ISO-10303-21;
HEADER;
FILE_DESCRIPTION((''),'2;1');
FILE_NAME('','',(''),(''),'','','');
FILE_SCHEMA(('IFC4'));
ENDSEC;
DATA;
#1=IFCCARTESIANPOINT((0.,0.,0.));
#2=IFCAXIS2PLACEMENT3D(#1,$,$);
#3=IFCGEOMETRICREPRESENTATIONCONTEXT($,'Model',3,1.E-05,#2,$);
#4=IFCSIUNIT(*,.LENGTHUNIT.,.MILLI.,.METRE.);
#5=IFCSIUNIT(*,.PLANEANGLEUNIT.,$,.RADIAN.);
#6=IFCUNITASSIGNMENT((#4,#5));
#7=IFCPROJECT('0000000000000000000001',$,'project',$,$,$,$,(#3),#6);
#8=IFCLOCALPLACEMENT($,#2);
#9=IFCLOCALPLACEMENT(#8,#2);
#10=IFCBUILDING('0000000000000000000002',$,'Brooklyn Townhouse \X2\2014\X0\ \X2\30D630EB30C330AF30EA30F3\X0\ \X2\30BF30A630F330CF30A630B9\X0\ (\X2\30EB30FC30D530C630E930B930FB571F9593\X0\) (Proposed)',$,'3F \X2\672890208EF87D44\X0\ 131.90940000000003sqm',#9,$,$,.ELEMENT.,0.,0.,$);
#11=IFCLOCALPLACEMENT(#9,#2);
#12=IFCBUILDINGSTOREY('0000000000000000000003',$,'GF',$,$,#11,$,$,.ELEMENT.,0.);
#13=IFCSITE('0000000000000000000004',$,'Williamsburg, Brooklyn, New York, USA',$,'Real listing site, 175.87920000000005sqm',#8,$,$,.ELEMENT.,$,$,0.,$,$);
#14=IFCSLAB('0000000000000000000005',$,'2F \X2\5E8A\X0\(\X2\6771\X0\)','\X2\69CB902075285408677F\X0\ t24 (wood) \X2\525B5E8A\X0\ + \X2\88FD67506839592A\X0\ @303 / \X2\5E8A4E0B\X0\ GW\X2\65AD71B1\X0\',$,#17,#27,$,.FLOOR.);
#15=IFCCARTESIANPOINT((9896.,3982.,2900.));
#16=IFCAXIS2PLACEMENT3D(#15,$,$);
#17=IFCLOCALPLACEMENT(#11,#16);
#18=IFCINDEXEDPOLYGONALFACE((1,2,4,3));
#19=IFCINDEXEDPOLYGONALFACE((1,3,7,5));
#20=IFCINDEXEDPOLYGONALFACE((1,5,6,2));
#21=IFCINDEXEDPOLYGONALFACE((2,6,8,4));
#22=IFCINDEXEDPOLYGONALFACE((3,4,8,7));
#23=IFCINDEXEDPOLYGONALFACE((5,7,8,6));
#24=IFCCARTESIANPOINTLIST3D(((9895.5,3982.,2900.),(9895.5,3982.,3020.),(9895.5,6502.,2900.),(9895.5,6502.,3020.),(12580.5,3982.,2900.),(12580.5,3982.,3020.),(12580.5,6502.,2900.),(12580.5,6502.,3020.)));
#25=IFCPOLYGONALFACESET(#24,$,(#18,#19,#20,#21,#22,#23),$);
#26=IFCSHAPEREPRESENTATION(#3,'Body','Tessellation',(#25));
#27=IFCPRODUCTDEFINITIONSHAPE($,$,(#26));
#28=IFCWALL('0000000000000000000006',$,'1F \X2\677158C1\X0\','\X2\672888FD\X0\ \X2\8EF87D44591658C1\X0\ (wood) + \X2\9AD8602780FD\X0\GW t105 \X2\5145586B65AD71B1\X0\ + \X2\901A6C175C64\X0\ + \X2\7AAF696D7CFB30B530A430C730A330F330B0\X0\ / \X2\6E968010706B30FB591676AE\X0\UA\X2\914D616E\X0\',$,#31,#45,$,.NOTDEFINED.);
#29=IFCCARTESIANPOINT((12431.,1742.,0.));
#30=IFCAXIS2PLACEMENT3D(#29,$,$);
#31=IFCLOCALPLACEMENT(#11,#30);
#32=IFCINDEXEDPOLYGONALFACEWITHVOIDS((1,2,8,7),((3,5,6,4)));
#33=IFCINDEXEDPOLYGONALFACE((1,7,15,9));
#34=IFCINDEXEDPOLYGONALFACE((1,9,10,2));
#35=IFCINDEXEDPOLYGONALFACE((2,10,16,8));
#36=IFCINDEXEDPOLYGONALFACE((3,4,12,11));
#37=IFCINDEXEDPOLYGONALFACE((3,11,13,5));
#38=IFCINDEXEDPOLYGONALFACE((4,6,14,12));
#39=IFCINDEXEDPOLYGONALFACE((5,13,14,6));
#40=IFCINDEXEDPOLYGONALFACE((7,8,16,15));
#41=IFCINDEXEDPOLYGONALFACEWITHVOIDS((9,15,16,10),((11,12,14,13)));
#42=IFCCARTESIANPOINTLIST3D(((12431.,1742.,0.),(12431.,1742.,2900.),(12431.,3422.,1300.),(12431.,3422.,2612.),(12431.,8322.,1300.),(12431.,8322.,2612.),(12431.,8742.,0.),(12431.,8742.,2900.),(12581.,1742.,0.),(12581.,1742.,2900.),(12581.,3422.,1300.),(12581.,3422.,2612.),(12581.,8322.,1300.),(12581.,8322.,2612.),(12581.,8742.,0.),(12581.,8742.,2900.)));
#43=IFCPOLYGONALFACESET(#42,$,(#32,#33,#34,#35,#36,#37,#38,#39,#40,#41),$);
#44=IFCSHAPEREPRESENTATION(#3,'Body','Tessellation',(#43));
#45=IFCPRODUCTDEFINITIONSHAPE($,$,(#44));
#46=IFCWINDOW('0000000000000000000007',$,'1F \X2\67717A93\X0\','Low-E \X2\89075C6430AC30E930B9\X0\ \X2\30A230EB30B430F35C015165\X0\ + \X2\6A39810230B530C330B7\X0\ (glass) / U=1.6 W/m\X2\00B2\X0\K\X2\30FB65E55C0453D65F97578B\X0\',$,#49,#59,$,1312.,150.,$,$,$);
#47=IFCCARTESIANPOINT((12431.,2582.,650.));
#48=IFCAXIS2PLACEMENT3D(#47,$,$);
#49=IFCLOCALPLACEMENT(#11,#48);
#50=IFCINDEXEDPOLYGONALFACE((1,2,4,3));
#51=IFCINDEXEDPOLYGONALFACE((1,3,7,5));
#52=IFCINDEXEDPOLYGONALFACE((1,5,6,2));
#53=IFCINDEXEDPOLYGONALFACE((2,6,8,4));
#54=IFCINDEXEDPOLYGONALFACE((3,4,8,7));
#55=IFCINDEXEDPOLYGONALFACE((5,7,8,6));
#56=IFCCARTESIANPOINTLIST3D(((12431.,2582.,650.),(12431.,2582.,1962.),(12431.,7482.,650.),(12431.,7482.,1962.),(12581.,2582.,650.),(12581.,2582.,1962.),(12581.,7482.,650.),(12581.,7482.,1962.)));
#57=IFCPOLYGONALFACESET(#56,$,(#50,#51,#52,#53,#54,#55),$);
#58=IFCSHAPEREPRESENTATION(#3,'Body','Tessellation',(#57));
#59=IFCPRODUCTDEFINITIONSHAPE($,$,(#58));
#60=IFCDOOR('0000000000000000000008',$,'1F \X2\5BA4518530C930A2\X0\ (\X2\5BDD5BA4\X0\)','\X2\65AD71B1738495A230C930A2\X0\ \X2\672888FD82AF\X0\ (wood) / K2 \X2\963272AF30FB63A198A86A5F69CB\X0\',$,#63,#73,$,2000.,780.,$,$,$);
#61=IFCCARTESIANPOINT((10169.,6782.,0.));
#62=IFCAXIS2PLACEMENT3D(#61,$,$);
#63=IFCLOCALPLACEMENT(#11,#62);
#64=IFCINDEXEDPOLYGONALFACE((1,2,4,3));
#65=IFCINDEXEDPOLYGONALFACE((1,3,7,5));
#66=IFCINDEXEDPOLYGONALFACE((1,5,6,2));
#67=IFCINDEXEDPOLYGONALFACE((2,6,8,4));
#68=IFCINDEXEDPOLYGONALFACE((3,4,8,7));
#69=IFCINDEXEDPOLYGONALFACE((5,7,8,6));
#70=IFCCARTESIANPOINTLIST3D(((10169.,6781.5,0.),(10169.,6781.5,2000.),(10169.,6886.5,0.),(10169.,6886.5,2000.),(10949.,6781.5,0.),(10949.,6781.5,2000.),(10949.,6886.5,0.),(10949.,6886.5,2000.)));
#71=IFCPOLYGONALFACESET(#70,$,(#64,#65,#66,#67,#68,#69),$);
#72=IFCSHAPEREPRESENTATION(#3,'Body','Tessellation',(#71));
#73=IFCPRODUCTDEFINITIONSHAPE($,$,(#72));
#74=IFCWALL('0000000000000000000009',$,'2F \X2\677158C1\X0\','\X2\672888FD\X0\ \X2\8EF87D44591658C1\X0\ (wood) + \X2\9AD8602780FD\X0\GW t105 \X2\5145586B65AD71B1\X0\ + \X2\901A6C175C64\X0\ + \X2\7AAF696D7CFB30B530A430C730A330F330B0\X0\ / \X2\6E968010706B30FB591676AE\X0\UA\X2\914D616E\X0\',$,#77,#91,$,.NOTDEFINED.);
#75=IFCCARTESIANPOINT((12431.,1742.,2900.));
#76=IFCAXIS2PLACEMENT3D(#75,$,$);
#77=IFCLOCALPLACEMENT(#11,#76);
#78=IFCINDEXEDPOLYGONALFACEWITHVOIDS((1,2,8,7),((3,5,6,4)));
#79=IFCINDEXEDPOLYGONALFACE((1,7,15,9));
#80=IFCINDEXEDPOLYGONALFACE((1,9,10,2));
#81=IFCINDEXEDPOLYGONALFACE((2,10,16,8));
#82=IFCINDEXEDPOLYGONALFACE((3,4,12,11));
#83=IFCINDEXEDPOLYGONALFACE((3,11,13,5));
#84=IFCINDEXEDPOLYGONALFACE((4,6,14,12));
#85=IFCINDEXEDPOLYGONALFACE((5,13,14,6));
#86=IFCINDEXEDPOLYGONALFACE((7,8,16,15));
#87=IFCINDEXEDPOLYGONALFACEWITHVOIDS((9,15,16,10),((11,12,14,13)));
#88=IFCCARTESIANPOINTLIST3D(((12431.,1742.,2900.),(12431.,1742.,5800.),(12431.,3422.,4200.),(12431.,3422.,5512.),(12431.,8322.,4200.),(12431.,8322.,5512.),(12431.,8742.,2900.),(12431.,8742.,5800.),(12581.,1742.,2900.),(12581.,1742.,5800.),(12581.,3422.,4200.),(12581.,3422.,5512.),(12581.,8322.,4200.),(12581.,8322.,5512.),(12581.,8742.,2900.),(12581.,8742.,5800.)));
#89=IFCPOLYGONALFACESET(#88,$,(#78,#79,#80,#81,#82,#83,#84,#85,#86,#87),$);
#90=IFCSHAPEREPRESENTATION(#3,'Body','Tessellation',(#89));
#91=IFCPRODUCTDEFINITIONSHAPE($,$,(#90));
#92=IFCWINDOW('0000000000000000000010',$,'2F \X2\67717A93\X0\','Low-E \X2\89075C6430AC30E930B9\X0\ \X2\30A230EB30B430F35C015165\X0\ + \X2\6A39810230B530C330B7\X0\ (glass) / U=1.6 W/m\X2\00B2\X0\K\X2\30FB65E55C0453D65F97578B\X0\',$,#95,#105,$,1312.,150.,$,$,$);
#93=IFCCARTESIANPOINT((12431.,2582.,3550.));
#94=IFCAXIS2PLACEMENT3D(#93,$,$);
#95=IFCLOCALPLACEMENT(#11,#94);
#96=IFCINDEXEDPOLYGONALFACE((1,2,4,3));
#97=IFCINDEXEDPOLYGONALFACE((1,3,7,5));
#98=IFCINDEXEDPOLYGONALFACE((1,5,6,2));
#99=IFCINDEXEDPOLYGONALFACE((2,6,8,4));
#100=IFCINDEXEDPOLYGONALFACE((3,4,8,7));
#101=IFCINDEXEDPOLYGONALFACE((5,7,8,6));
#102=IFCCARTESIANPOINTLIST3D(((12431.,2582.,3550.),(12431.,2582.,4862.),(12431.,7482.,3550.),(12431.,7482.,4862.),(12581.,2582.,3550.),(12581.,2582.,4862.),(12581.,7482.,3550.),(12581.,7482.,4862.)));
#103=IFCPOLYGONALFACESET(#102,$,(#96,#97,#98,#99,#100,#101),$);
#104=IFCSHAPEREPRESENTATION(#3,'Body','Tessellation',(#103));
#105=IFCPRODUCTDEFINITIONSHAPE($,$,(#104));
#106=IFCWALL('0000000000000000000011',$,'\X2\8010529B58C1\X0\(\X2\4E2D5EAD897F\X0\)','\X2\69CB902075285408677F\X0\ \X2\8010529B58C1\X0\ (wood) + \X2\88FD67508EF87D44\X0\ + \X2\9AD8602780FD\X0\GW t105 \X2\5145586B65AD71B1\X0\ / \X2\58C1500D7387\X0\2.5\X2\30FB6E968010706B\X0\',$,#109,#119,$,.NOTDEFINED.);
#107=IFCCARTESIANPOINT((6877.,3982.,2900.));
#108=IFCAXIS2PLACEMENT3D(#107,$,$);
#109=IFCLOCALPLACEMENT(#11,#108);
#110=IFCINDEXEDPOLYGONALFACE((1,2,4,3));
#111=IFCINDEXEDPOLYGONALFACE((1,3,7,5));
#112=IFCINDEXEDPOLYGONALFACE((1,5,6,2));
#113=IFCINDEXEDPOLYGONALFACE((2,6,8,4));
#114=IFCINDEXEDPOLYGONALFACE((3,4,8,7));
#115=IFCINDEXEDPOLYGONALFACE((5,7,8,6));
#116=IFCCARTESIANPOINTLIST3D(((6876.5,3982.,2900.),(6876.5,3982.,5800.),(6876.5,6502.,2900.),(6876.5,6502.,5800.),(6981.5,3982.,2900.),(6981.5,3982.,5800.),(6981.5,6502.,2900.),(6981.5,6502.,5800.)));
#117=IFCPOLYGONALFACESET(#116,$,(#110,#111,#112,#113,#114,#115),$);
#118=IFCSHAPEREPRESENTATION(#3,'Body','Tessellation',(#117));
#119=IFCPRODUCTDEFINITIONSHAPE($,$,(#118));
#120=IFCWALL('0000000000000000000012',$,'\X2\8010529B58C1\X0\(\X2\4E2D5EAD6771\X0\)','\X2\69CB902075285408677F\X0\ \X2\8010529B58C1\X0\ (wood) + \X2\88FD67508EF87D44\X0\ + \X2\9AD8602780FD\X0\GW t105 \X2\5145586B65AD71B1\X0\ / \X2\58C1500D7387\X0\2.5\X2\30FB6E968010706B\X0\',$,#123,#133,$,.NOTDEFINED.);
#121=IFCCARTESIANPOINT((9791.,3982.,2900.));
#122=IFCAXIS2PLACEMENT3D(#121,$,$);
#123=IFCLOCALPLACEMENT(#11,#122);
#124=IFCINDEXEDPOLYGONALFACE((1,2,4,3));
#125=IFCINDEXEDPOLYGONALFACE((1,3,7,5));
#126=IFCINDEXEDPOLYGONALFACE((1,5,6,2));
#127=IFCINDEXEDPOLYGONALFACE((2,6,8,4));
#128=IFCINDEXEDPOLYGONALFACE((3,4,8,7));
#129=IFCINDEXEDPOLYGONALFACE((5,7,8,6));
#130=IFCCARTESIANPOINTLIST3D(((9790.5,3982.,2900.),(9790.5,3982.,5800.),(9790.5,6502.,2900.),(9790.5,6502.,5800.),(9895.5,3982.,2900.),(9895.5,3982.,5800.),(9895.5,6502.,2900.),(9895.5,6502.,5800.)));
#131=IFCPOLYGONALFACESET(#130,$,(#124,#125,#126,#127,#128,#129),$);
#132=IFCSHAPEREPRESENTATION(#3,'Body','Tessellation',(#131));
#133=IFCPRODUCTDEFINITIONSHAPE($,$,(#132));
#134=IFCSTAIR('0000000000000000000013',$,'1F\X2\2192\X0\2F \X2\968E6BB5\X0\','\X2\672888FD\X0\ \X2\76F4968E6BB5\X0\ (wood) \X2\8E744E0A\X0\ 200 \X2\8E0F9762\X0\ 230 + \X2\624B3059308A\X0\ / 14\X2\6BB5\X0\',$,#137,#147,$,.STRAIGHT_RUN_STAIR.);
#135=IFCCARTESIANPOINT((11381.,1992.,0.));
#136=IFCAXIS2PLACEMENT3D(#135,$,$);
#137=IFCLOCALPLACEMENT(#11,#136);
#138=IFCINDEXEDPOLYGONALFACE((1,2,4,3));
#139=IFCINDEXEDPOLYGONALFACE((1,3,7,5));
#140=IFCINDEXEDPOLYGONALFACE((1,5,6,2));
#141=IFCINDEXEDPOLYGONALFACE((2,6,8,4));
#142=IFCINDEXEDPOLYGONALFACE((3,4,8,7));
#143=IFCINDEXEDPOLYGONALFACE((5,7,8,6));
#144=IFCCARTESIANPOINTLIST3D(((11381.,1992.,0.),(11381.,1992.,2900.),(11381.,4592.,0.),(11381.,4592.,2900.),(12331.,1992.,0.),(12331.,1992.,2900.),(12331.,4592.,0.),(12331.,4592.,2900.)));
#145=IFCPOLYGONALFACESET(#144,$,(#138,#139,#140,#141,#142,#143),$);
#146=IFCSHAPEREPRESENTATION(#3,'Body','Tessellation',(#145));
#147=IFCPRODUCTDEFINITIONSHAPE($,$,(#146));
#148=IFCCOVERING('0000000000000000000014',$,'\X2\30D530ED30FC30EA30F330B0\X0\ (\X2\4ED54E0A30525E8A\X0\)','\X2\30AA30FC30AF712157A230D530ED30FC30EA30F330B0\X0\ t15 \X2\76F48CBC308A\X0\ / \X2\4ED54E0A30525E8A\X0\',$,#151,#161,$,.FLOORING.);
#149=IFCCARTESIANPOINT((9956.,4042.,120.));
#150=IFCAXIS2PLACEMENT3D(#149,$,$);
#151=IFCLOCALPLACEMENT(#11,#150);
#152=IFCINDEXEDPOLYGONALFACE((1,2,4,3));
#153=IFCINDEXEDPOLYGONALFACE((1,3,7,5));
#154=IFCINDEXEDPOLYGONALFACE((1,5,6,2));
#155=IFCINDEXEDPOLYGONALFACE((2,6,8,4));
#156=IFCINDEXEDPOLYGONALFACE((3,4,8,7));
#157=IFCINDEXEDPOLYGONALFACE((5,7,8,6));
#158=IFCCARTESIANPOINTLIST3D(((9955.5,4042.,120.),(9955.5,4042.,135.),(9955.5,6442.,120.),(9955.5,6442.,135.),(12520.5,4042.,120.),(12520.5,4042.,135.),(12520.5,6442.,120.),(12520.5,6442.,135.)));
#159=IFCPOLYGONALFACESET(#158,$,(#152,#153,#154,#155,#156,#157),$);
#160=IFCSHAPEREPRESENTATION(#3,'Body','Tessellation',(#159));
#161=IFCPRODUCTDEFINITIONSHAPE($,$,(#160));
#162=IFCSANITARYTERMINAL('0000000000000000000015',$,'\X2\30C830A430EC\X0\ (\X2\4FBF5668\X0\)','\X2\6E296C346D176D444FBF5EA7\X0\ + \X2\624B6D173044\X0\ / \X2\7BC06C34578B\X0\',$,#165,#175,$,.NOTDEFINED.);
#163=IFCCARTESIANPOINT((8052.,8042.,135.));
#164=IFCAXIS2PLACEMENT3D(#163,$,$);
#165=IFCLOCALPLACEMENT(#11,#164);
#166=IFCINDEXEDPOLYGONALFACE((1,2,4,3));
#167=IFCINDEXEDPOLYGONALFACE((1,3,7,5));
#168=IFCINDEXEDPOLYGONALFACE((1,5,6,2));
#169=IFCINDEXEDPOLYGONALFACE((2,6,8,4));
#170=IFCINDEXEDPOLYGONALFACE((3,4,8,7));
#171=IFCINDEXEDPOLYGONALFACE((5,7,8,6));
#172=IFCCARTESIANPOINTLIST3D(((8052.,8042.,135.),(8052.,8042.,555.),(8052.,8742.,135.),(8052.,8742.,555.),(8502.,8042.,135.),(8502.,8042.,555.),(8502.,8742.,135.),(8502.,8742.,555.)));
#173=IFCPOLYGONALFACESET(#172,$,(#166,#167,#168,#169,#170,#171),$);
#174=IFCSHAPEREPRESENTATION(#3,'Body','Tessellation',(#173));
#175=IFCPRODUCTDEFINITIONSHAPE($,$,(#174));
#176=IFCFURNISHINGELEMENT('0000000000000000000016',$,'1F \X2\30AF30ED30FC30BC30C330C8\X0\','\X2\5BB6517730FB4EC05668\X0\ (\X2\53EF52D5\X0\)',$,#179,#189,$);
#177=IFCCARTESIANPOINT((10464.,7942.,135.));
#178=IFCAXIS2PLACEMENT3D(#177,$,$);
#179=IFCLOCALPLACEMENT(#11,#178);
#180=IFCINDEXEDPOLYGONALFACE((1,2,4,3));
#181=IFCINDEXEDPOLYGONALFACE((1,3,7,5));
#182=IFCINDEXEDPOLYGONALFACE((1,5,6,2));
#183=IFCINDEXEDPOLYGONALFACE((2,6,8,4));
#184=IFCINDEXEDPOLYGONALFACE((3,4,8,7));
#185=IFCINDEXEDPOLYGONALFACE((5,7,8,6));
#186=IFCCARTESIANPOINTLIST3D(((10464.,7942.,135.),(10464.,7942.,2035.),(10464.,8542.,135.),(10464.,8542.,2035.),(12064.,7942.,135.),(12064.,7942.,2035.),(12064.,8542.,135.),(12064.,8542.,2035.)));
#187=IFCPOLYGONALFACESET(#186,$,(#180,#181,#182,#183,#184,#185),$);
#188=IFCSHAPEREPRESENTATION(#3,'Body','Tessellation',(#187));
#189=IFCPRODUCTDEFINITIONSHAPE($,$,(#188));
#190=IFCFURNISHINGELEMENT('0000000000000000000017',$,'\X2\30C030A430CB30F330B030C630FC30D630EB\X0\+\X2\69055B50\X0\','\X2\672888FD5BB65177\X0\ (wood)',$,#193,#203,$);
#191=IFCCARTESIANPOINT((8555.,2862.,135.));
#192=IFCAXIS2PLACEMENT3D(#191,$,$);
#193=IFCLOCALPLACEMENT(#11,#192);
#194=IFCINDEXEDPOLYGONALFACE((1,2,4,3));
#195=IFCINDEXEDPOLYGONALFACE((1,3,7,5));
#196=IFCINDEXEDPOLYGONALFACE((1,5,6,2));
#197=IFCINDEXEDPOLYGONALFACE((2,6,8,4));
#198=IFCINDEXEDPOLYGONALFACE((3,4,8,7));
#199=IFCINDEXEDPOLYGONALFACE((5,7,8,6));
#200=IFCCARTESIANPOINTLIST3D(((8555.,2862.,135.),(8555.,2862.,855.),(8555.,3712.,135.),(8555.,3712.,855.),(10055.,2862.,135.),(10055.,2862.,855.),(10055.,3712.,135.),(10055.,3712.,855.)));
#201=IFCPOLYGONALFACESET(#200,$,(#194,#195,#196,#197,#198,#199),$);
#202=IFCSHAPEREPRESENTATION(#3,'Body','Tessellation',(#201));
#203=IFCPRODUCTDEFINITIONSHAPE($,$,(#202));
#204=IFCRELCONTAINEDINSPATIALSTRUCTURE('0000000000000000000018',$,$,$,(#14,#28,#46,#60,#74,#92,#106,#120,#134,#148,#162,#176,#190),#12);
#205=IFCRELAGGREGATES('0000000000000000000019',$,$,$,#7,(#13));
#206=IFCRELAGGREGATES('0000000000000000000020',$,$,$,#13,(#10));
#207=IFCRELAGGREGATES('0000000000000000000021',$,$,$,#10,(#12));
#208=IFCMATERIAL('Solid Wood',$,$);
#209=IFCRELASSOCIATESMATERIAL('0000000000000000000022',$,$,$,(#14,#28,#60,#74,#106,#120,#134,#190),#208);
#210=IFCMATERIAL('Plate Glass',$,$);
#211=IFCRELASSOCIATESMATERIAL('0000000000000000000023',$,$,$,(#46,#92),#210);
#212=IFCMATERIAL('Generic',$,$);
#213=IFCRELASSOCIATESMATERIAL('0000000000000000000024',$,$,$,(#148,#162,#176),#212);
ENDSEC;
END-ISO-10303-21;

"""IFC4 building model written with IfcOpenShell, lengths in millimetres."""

from ifc_helpers import new_model, si_unit, frame, frame_2d, origin, place, context, project, spatial, rectangle, extrude, material, element, fill, save


model = new_model("IFC4")

# Units and contexts
model_context = context("Model", 3, precision=1e-05, world=origin())
ifc_project = project(units=[si_unit("LENGTHUNIT", "METRE", prefix="MILLI"), si_unit("PLANEANGLEUNIT", "RADIAN")], contexts=[model_context])

# Site, building, storey
site_placement = place(None, origin())
site = spatial("IfcSite", under=ifc_project, at=site_placement, Name="Williamsburg, Brooklyn, New York, USA", ObjectType="Real listing site, 175.87920000000005sqm", CompositionType="ELEMENT", RefElevation=0.0)
building_placement = place(site_placement, origin())
building = spatial("IfcBuilding", under=site, at=building_placement, Name="Brooklyn Townhouse — ブルックリン タウンハウス (ルーフテラス・土間) (Proposed)", ObjectType="3F 木造軸組 131.90940000000003sqm", CompositionType="ELEMENT", ElevationOfRefHeight=0.0, ElevationOfTerrain=0.0)
storey_placement = place(building_placement, origin())
storey = spatial("IfcBuildingStorey", under=building, at=storey_placement, Name="GF", CompositionType="ELEMENT", Elevation=0.0)

# Slab
ifc_material_1 = material(Name="Solid Wood")
slab_1_placement = place(storey_placement, frame((9896.0, 3982.0, 2900.0)))
element("IfcSlab", 1, at=slab_1_placement, inside=storey, material=ifc_material_1, Name="2F 床(東)", Description="構造用合板 t24 (wood) 剛床 + 製材根太 @303 / 床下 GW断熱", PredefinedType="FLOOR", context=model_context, shape_type="SweptSolid", body=[
    extrude(rectangle(XDim=2685.0, YDim=2520.0, at=frame_2d((1342.0, 1260.0))), frame((9896.0, 3982.0, 2900.0)), (0.0, 0.0, 1.0), 120.0),
])

# Wall, opening, window
wall_1_placement = place(storey_placement, frame((12431.0, 1742.0, 0.0)))
wall_1 = element("IfcWall", 2, at=wall_1_placement, inside=storey, material=ifc_material_1, Name="1F 東壁", Description="木製 軸組外壁 (wood) + 高性能GW t105 充填断熱 + 通気層 + 窯業系サイディング / 準耐火・外皮UA配慮", PredefinedType="NOTDEFINED", context=model_context, shape_type="SweptSolid", body=[
    extrude(rectangle(XDim=150.0, YDim=7000.0, at=frame_2d((75.0, 3500.0))), frame((12431.0, 1742.0, 0.0)), (0.0, 0.0, 1.0), 2900.0),
])
opening_1_placement = place(storey_placement, frame((12431.0, 2582.0, 650.0)))
opening_1 = element("IfcOpeningElement", 3, at=opening_1_placement, cuts=wall_1, PredefinedType="NOTDEFINED", context=model_context, shape_type="SweptSolid", body=[
    extrude(rectangle(XDim=150.0, YDim=4900.0, at=frame_2d((75.0, 2450.0))), frame((12431.0, 2582.0, 650.0)), (0.0, 0.0, 1.0), 1312.0),
])
ifc_material_2 = material(Name="Plate Glass")
window_1_placement = place(storey_placement, frame((12431.0, 2582.0, 650.0)))
window_1 = element("IfcWindow", 4, at=window_1_placement, inside=storey, material=ifc_material_2, Name="1F 東窓", Description="Low-E 複層ガラス アルゴン封入 + 樹脂サッシ (glass) / U=1.6 W/m²K・日射取得型", OverallHeight=1312.0, OverallWidth=150.0, context=model_context, shape_type="SweptSolid", body=[
    extrude(rectangle(XDim=150.0, YDim=4900.0, at=frame_2d((75.0, 2450.0))), frame((12431.0, 2582.0, 650.0)), (0.0, 0.0, 1.0), 1312.0),
])
fill(opening_1, window_1)

# Door
door_placement = place(storey_placement, frame((10169.0, 6782.0, 0.0)))
element("IfcDoor", 5, at=door_placement, inside=storey, material=ifc_material_1, Name="1F 室内ドア (寝室)", Description="断熱玄関ドア 木製芯 (wood) / K2 防犯・採風機構", OverallHeight=2000.0, OverallWidth=780.0, context=model_context, shape_type="SweptSolid", body=[
    extrude(rectangle(XDim=780.0, YDim=105.0, at=frame_2d((390.0, 52.0))), frame((10169.0, 6782.0, 0.0)), (0.0, 0.0, 1.0), 2000.0),
])

# Wall, opening, window
wall_2_placement = place(storey_placement, frame((12431.0, 1742.0, 2900.0)))
wall_2 = element("IfcWall", 6, at=wall_2_placement, inside=storey, material=ifc_material_1, Name="2F 東壁", Description="木製 軸組外壁 (wood) + 高性能GW t105 充填断熱 + 通気層 + 窯業系サイディング / 準耐火・外皮UA配慮", PredefinedType="NOTDEFINED", context=model_context, shape_type="SweptSolid", body=[
    extrude(rectangle(XDim=150.0, YDim=7000.0, at=frame_2d((75.0, 3500.0))), frame((12431.0, 1742.0, 2900.0)), (0.0, 0.0, 1.0), 2900.0),
])
opening_2_placement = place(storey_placement, frame((12431.0, 2582.0, 3550.0)))
opening_2 = element("IfcOpeningElement", 7, at=opening_2_placement, cuts=wall_2, PredefinedType="NOTDEFINED", context=model_context, shape_type="SweptSolid", body=[
    extrude(rectangle(XDim=150.0, YDim=4900.0, at=frame_2d((75.0, 2450.0))), frame((12431.0, 2582.0, 3550.0)), (0.0, 0.0, 1.0), 1312.0),
])
window_2_placement = place(storey_placement, frame((12431.0, 2582.0, 3550.0)))
window_2 = element("IfcWindow", 8, at=window_2_placement, inside=storey, material=ifc_material_2, Name="2F 東窓", Description="Low-E 複層ガラス アルゴン封入 + 樹脂サッシ (glass) / U=1.6 W/m²K・日射取得型", OverallHeight=1312.0, OverallWidth=150.0, context=model_context, shape_type="SweptSolid", body=[
    extrude(rectangle(XDim=150.0, YDim=4900.0, at=frame_2d((75.0, 2450.0))), frame((12431.0, 2582.0, 3550.0)), (0.0, 0.0, 1.0), 1312.0),
])
fill(opening_2, window_2)

# Walls
wall_3_placement = place(storey_placement, frame((6877.0, 3982.0, 2900.0)))
element("IfcWall", 9, at=wall_3_placement, inside=storey, material=ifc_material_1, Name="耐力壁(中庭西)", Description="構造用合板 耐力壁 (wood) + 製材軸組 + 高性能GW t105 充填断熱 / 壁倍率2.5・準耐火", PredefinedType="NOTDEFINED", context=model_context, shape_type="SweptSolid", body=[
    extrude(rectangle(XDim=105.0, YDim=2520.0, at=frame_2d((52.0, 1260.0))), frame((6877.0, 3982.0, 2900.0)), (0.0, 0.0, 1.0), 2900.0),
])
wall_4_placement = place(storey_placement, frame((9791.0, 3982.0, 2900.0)))
element("IfcWall", 10, at=wall_4_placement, inside=storey, material=ifc_material_1, Name="耐力壁(中庭東)", Description="構造用合板 耐力壁 (wood) + 製材軸組 + 高性能GW t105 充填断熱 / 壁倍率2.5・準耐火", PredefinedType="NOTDEFINED", context=model_context, shape_type="SweptSolid", body=[
    extrude(rectangle(XDim=105.0, YDim=2520.0, at=frame_2d((52.0, 1260.0))), frame((9791.0, 3982.0, 2900.0)), (0.0, 0.0, 1.0), 2900.0),
])

# Stair
stair_placement = place(storey_placement, frame((11381.0, 1992.0, 0.0)))
element("IfcStair", 11, at=stair_placement, inside=storey, material=ifc_material_1, Name="1F→2F 階段", Description="木製 直階段 (wood) 蹴上 200 踏面 230 + 手すり / 14段", PredefinedType="STRAIGHT_RUN_STAIR", context=model_context, shape_type="SweptSolid", body=[
    extrude(rectangle(XDim=950.0, YDim=2600.0, at=frame_2d((475.0, 1300.0))), frame((11381.0, 1992.0, 0.0)), (0.0, 0.0, 1.0), 2900.0),
])

# Covering
ifc_material_3 = material(Name="Generic")
covering_placement = place(storey_placement, frame((9956.0, 4042.0, 120.0)))
element("IfcCovering", 12, at=covering_placement, inside=storey, material=ifc_material_3, Name="フローリング (仕上げ床)", Description="オーク無垢フローリング t15 直貼り / 仕上げ床", PredefinedType="FLOORING", context=model_context, shape_type="SweptSolid", body=[
    extrude(rectangle(XDim=2565.0, YDim=2400.0, at=frame_2d((1282.0, 1200.0))), frame((9956.0, 4042.0, 120.0)), (0.0, 0.0, 1.0), 15.0),
])

# Sanitary terminal
sanitary_terminal_placement = place(storey_placement, frame((8052.0, 8042.0, 135.0)))
element("IfcSanitaryTerminal", 13, at=sanitary_terminal_placement, inside=storey, material=ifc_material_3, Name="トイレ (便器)", Description="温水洗浄便座 + 手洗い / 節水型", PredefinedType="NOTDEFINED", context=model_context, shape_type="SweptSolid", body=[
    extrude(rectangle(XDim=450.0, YDim=700.0, at=frame_2d((225.0, 350.0))), frame((8052.0, 8042.0, 135.0)), (0.0, 0.0, 1.0), 420.0),
])

# Furnishing elements
furnishing_1_placement = place(storey_placement, frame((10464.0, 7942.0, 135.0)))
element("IfcFurnishingElement", 14, at=furnishing_1_placement, inside=storey, material=ifc_material_3, Name="1F クローゼット", Description="家具・什器 (可動)", context=model_context, shape_type="SweptSolid", body=[
    extrude(rectangle(XDim=1600.0, YDim=600.0, at=frame_2d((800.0, 300.0))), frame((10464.0, 7942.0, 135.0)), (0.0, 0.0, 1.0), 1900.0),
])
furnishing_2_placement = place(storey_placement, frame((8555.0, 2862.0, 135.0)))
element("IfcFurnishingElement", 15, at=furnishing_2_placement, inside=storey, material=ifc_material_1, Name="ダイニングテーブル+椅子", Description="木製家具 (wood)", context=model_context, shape_type="SweptSolid", body=[
    extrude(rectangle(XDim=1500.0, YDim=850.0, at=frame_2d((750.0, 425.0))), frame((8555.0, 2862.0, 135.0)), (0.0, 0.0, 1.0), 720.0),
])

save(model, "model.ifc")
